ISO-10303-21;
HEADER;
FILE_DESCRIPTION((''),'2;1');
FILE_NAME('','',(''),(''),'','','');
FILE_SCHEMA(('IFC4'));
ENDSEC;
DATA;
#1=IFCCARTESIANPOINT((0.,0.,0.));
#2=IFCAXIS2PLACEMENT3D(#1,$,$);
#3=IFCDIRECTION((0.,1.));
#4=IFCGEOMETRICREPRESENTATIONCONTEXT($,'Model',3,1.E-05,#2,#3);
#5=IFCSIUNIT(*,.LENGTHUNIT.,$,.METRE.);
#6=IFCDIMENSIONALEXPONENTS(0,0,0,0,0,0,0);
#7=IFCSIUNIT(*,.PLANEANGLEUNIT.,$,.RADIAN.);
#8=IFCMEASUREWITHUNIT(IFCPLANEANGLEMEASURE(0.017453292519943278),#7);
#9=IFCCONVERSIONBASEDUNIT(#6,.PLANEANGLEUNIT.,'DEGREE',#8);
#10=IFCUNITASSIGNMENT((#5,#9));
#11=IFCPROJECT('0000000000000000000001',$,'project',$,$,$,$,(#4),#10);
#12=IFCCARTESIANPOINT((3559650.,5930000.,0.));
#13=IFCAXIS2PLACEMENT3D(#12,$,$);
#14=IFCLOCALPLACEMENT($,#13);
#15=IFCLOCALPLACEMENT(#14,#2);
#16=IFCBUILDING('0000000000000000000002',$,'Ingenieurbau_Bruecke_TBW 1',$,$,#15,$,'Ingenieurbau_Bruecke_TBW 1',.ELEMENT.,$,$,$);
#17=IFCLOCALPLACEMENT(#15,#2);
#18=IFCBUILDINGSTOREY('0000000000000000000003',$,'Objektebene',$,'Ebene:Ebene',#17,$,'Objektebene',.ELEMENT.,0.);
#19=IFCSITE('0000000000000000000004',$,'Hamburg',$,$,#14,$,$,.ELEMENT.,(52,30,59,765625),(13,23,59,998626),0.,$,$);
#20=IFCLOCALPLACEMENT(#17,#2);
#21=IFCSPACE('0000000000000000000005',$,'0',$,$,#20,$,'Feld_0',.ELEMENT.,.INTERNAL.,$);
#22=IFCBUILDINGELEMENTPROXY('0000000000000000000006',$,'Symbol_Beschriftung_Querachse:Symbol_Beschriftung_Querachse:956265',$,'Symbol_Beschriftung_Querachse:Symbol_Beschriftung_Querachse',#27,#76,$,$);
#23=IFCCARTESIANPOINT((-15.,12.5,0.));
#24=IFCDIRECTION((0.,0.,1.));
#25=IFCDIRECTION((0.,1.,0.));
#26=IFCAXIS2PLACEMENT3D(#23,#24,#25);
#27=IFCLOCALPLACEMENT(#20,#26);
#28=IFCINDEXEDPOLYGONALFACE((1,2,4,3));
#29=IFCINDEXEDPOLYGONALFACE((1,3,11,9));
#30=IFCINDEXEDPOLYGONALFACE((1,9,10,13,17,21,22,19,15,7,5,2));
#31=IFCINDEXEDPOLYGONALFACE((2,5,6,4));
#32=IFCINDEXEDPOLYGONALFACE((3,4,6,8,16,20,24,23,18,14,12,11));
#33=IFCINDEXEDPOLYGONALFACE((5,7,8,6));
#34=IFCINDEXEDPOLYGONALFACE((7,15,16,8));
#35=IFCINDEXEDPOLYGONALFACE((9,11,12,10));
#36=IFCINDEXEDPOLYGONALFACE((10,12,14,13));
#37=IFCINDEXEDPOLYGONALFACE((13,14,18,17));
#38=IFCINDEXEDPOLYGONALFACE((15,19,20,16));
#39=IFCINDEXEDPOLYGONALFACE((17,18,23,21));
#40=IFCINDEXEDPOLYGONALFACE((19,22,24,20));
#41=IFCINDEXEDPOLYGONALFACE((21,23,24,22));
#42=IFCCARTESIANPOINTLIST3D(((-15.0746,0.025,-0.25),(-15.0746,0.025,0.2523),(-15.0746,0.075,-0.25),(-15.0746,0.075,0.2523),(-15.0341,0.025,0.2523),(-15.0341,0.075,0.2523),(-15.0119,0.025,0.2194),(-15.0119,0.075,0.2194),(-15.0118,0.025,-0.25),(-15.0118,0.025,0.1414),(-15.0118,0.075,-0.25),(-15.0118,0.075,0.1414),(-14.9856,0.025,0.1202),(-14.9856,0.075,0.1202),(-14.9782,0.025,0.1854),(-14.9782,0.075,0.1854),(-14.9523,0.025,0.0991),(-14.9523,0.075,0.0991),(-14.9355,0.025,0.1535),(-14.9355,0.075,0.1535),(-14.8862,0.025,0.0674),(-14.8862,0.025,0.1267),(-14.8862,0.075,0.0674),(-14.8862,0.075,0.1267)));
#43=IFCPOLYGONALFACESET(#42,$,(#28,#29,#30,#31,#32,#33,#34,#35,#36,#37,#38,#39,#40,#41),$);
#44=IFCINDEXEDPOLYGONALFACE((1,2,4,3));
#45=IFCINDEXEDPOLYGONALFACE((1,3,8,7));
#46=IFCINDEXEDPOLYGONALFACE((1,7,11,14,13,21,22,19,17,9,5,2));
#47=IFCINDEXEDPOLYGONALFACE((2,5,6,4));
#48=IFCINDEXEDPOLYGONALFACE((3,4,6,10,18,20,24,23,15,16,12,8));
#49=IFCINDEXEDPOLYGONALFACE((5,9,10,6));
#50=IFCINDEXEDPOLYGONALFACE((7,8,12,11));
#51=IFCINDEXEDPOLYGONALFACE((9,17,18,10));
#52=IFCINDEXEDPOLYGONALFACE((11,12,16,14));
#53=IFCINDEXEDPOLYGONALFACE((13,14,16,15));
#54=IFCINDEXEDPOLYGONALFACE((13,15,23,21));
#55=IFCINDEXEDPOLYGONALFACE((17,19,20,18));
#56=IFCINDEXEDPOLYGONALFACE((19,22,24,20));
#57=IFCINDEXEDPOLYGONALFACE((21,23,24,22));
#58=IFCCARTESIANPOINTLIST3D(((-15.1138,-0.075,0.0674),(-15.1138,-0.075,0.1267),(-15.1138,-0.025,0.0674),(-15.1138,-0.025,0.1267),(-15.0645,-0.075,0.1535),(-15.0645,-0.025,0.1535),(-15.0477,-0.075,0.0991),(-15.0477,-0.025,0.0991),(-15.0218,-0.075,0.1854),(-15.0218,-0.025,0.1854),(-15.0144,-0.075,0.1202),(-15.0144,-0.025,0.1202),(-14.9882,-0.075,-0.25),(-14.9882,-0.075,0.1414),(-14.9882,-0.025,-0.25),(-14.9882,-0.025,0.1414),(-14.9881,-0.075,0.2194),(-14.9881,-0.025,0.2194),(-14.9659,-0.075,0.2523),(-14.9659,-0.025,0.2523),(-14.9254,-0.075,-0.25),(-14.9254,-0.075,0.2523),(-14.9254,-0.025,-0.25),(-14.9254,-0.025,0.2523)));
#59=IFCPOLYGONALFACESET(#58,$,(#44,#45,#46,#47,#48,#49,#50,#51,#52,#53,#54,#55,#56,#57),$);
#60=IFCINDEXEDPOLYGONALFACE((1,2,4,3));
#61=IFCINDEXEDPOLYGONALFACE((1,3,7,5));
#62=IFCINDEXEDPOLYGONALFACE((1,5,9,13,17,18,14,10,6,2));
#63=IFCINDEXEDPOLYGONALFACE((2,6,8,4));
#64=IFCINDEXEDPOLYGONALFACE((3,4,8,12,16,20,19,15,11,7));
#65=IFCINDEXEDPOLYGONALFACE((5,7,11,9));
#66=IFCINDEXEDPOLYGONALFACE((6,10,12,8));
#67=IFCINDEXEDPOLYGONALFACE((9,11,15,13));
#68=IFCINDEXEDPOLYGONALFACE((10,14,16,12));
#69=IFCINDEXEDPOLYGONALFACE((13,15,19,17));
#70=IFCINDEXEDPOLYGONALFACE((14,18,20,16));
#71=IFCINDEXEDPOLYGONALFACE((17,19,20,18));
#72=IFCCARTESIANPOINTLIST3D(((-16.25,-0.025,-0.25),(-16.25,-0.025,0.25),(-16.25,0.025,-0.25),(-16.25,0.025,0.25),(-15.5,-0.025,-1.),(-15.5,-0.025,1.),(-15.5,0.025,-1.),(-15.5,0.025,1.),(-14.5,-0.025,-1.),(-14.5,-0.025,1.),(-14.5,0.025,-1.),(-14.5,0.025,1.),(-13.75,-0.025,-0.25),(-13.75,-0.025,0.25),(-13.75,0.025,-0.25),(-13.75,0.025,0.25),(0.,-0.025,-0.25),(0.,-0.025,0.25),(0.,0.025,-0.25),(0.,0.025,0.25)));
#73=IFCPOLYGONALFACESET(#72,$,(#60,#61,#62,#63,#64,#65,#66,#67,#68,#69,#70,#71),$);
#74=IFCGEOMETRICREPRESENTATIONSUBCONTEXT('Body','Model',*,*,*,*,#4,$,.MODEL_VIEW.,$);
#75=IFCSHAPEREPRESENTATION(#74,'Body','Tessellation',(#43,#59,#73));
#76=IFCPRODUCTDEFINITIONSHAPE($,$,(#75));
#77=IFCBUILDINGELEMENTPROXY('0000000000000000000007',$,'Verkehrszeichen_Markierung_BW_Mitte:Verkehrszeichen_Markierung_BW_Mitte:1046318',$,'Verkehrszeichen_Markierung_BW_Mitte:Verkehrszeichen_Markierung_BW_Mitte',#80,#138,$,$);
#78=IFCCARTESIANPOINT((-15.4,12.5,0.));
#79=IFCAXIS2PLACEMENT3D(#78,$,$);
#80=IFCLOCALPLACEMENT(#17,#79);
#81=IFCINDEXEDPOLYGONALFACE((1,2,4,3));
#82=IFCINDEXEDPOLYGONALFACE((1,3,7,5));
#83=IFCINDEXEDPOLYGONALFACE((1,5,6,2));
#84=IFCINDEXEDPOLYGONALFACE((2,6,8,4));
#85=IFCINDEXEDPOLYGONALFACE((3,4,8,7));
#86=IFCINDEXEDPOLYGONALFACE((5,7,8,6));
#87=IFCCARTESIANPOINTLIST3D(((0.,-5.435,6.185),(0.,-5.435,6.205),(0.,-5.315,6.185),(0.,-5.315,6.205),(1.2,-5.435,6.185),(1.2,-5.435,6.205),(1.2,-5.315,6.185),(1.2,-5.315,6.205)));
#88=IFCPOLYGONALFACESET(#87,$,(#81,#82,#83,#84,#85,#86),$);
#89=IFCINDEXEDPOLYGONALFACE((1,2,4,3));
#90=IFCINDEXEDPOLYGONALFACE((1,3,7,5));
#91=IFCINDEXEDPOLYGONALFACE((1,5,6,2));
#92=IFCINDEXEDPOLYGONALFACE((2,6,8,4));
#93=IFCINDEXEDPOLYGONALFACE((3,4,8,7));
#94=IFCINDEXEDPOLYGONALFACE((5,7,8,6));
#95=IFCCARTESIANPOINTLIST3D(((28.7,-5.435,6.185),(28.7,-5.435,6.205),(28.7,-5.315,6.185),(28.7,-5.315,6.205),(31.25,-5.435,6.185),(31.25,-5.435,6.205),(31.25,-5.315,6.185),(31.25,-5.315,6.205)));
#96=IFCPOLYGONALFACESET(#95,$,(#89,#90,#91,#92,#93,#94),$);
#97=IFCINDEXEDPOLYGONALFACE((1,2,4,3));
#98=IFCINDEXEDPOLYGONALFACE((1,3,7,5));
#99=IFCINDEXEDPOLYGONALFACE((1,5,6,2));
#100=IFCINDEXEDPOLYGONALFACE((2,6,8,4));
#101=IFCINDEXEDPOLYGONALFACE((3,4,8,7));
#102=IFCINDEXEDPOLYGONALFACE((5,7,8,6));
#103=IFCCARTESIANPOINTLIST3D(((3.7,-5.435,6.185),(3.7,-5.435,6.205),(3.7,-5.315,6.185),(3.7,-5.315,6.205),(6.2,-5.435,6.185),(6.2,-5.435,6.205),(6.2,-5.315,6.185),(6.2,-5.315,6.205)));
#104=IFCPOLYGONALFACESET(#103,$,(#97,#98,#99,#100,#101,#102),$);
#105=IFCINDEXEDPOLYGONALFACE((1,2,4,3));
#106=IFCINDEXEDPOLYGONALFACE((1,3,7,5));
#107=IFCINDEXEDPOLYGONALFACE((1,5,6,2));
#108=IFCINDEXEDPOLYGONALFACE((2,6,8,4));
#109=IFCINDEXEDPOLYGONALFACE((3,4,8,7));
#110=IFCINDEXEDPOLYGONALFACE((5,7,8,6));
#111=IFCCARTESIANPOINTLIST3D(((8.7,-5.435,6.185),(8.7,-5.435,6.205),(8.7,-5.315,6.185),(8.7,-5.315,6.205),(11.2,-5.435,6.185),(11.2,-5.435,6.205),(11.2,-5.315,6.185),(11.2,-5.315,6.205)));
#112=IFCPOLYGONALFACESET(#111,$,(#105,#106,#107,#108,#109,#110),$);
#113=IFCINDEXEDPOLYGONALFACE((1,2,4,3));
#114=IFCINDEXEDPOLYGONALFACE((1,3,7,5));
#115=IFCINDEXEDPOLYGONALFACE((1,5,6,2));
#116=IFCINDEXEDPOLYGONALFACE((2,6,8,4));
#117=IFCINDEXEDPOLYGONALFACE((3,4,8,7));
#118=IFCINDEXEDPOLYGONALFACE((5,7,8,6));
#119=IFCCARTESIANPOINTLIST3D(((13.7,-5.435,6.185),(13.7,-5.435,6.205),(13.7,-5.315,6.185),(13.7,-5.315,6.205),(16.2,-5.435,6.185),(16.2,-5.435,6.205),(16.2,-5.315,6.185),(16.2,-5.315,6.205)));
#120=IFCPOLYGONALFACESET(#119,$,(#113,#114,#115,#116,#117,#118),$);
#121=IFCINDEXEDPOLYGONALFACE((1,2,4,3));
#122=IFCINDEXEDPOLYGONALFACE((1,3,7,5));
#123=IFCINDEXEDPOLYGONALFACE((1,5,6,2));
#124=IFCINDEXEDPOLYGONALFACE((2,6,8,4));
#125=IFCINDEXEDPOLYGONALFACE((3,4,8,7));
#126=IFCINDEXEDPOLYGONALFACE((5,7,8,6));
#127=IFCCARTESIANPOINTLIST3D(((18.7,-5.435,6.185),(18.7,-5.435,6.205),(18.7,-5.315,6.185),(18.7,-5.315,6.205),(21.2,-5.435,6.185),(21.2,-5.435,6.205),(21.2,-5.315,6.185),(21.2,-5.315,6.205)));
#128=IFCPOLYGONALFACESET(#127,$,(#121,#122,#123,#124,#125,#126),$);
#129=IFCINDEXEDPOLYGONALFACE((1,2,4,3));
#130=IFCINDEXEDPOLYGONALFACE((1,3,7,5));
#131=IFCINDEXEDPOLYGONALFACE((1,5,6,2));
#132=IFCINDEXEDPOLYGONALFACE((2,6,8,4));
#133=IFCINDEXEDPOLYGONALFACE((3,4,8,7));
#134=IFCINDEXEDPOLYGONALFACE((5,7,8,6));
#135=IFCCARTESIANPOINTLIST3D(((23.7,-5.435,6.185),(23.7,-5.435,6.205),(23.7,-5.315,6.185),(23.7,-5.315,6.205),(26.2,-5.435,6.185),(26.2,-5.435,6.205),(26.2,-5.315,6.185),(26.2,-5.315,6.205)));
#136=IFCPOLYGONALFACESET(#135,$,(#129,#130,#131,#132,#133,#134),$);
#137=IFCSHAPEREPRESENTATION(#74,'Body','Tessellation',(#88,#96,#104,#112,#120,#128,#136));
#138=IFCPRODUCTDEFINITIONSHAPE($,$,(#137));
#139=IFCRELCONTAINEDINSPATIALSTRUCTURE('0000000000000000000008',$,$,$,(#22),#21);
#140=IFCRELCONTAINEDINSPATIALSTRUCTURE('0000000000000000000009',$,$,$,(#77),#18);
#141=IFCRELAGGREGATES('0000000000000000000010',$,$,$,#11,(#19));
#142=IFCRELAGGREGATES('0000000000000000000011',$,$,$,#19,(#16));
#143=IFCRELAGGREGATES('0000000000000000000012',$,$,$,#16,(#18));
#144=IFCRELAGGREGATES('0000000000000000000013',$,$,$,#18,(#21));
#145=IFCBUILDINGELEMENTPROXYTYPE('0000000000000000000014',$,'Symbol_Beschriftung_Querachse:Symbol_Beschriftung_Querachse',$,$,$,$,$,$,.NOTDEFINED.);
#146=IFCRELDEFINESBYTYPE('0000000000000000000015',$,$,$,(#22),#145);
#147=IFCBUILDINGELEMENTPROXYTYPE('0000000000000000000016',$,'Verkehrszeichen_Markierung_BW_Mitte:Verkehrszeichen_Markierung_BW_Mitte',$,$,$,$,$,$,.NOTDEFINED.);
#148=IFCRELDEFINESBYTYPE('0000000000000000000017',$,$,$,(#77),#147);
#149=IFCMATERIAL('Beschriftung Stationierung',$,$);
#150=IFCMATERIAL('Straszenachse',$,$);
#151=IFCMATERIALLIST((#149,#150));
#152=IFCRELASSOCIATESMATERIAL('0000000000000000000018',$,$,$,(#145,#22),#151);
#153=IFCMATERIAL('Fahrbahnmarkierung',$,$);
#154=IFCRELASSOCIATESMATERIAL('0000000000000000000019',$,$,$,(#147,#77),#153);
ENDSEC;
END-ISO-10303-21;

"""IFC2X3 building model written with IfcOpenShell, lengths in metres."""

from ifc_helpers import new_model, entity, si_unit, converted_unit, direction, frame, frame_2d, origin, place, context, subcontext, project, spatial, polyline, rectangle, outline, extrude, source, transform, mapped, material, material_list, type_object, type_shapes, element, save


model = new_model("IFC2X3")

# Units and contexts
model_context = context("Model", 3, precision=1e-05, world=origin(), true_north=direction((0.0, 1.0)))
body_context = subcontext(model_context, "Body", "Model", "MODEL_VIEW")
ifc_project = project(units=[si_unit("LENGTHUNIT", "METRE"), converted_unit("PLANEANGLEUNIT", "DEGREE", entity("IfcPlaneAngleMeasure", 0.017453292519943278), si_unit("PLANEANGLEUNIT", "RADIAN"), dimensions=[0, 0, 0, 0, 0, 0, 0])], contexts=[model_context])

# Site, building, storey
site_placement = place(None, frame((3559650.0, 5930000.0, 0.0)))
site = spatial("IfcSite", under=ifc_project, at=site_placement, Name="Hamburg", CompositionType="ELEMENT", RefLatitude=(52, 30, 59, 765625), RefLongitude=(13, 23, 59, 998626), RefElevation=0.0)
building_placement = place(site_placement, origin())
building = spatial("IfcBuilding", under=site, at=building_placement, Name="Ingenieurbau_Bruecke_TBW 1", LongName="Ingenieurbau_Bruecke_TBW 1", CompositionType="ELEMENT")
storey_placement = place(building_placement, origin())
storey = spatial("IfcBuildingStorey", under=building, at=storey_placement, Name="Objektebene", ObjectType="Ebene:Ebene", LongName="Objektebene", CompositionType="ELEMENT", Elevation=0.0)

# Shared definitions
space_placement = place(storey_placement, origin())
space = spatial("IfcSpace", under=storey, at=space_placement, Name="0", LongName="Feld_0", CompositionType="ELEMENT", InteriorOrExteriorSpace="INTERNAL")

# Building element proxies
ifc_material_1 = material(Name="Beschriftung Stationierung")
ifc_material_2 = material(Name="Straszenachse")
ifc_material_list_1 = material_list([ifc_material_1, ifc_material_2])
building_element_proxy_type_1 = type_object("IfcBuildingElementProxyType", Name="Symbol_Beschriftung_Querachse:Symbol_Beschriftung_Querachse", PredefinedType="NOTDEFINED", material=ifc_material_list_1)
shared_shape_1 = source(origin(), body_context, "Body", "SweptSolid", [
    extrude(outline(polyline([(-0.3431, -0.0877), (0.1591, -0.0877), (0.1591, -0.0472), (0.1262, -0.025), (0.0923, 0.0087), (0.0604, 0.0514), (0.0336, 0.1007), (-0.0258, 0.1007), (0.0059, 0.0346), (0.0271, 0.0013), (0.0483, -0.0249), (-0.3431, -0.0249), (-0.3431, -0.0877)])), frame((-14.9869, 0.025, 0.0931), z_axis=(0.0, 1.0, 0.0), x_axis=(0.0, 0.0, 1.0)), (0.0, 0.0, 1.0), 0.05),
    extrude(outline(polyline([(-0.0877, -0.3431), (-0.0249, -0.3431), (-0.0249, 0.0483), (0.0013, 0.0271), (0.0346, 0.0059), (0.1007, -0.0258), (0.1007, 0.0336), (0.0514, 0.0604), (0.0087, 0.0923), (-0.025, 0.1262), (-0.0472, 0.1591), (-0.0877, 0.1591), (-0.0877, -0.3431)])), frame((-15.0131, -0.075, 0.0931), z_axis=(0.0, 1.0, 0.0), x_axis=(-1.0, 0.0, 0.0)), (0.0, 0.0, 1.0), 0.05),
    extrude(outline(polyline([(-12.0, 0.25), (-12.0, -0.25), (1.75, -0.25), (2.5, -1.0), (3.5, -1.0), (4.25, -0.25), (4.25, 0.25), (3.5, 1.0), (2.5, 1.0), (1.75, 0.25), (-12.0, 0.25)])), frame((-12.0, -0.025, 0.0), z_axis=(0.0, -1.0, 0.0), x_axis=(-1.0, 0.0, 0.0)), (0.0, 0.0, -1.0), 0.05),
])
type_shapes(building_element_proxy_type_1, [shared_shape_1])
proxy_1_placement = place(space_placement, frame((-15.0, 12.5, 0.0), z_axis=(0.0, 0.0, 1.0), x_axis=(0.0, 1.0, 0.0)))
element("IfcBuildingElementProxy", 1, at=proxy_1_placement, inside=space, type_object=building_element_proxy_type_1, material=ifc_material_list_1, Name="Symbol_Beschriftung_Querachse:Symbol_Beschriftung_Querachse:956265", ObjectType="Symbol_Beschriftung_Querachse:Symbol_Beschriftung_Querachse", context=body_context, shape_type="MappedRepresentation", body=[
    mapped(shared_shape_1, transform((0.0, 0.0, 0.0), scale=1.0)),
])
ifc_material_3 = material(Name="Fahrbahnmarkierung")
building_element_proxy_type_2 = type_object("IfcBuildingElementProxyType", Name="Verkehrszeichen_Markierung_BW_Mitte:Verkehrszeichen_Markierung_BW_Mitte", PredefinedType="NOTDEFINED", material=ifc_material_3)
shared_shape_2 = source(origin(), body_context, "Body", "SweptSolid", [
    extrude(rectangle(XDim=1.2, YDim=0.12, at=frame_2d((0.0, 0.0), x_axis=(1.0, 0.0))), frame((0.6, -5.375, 6.185)), (0.0, 0.0, 1.0), 0.02),
    extrude(rectangle(XDim=0.12, YDim=2.55, at=frame_2d((0.0, 0.0), x_axis=(1.0, 0.0))), frame((29.975, -5.375, 6.185), z_axis=(0.0, 0.0, 1.0), x_axis=(0.0, 1.0, 0.0)), (0.0, 0.0, 1.0), 0.02),
    extrude(rectangle(XDim=0.12, YDim=2.5, at=frame_2d((0.0, 0.0), x_axis=(1.0, 0.0))), frame((4.95, -5.375, 6.185), z_axis=(0.0, 0.0, 1.0), x_axis=(0.0, 1.0, 0.0)), (0.0, 0.0, 1.0), 0.02),
    extrude(rectangle(XDim=0.12, YDim=2.5, at=frame_2d((0.0, 0.0), x_axis=(1.0, 0.0))), frame((9.95, -5.375, 6.185), z_axis=(0.0, 0.0, 1.0), x_axis=(0.0, 1.0, 0.0)), (0.0, 0.0, 1.0), 0.02),
    extrude(rectangle(XDim=0.12, YDim=2.5, at=frame_2d((0.0, 0.0), x_axis=(1.0, 0.0))), frame((14.95, -5.375, 6.185), z_axis=(0.0, 0.0, 1.0), x_axis=(0.0, 1.0, 0.0)), (0.0, 0.0, 1.0), 0.02),
    extrude(rectangle(XDim=0.12, YDim=2.5, at=frame_2d((0.0, 0.0), x_axis=(1.0, 0.0))), frame((19.95, -5.375, 6.185), z_axis=(0.0, 0.0, 1.0), x_axis=(0.0, 1.0, 0.0)), (0.0, 0.0, 1.0), 0.02),
    extrude(rectangle(XDim=0.12, YDim=2.5, at=frame_2d((0.0, 0.0), x_axis=(1.0, 0.0))), frame((24.95, -5.375, 6.185), z_axis=(0.0, 0.0, 1.0), x_axis=(0.0, 1.0, 0.0)), (0.0, 0.0, 1.0), 0.02),
])
type_shapes(building_element_proxy_type_2, [shared_shape_2])
proxy_2_placement = place(storey_placement, frame((-15.4, 12.5, 0.0)))
element("IfcBuildingElementProxy", 2, at=proxy_2_placement, inside=storey, type_object=building_element_proxy_type_2, material=ifc_material_3, Name="Verkehrszeichen_Markierung_BW_Mitte:Verkehrszeichen_Markierung_BW_Mitte:1046318", ObjectType="Verkehrszeichen_Markierung_BW_Mitte:Verkehrszeichen_Markierung_BW_Mitte", context=body_context, shape_type="MappedRepresentation", body=[
    mapped(shared_shape_2, transform((0.0, 0.0, 0.0), scale=1.0)),
])

save(model, "model.ifc")
